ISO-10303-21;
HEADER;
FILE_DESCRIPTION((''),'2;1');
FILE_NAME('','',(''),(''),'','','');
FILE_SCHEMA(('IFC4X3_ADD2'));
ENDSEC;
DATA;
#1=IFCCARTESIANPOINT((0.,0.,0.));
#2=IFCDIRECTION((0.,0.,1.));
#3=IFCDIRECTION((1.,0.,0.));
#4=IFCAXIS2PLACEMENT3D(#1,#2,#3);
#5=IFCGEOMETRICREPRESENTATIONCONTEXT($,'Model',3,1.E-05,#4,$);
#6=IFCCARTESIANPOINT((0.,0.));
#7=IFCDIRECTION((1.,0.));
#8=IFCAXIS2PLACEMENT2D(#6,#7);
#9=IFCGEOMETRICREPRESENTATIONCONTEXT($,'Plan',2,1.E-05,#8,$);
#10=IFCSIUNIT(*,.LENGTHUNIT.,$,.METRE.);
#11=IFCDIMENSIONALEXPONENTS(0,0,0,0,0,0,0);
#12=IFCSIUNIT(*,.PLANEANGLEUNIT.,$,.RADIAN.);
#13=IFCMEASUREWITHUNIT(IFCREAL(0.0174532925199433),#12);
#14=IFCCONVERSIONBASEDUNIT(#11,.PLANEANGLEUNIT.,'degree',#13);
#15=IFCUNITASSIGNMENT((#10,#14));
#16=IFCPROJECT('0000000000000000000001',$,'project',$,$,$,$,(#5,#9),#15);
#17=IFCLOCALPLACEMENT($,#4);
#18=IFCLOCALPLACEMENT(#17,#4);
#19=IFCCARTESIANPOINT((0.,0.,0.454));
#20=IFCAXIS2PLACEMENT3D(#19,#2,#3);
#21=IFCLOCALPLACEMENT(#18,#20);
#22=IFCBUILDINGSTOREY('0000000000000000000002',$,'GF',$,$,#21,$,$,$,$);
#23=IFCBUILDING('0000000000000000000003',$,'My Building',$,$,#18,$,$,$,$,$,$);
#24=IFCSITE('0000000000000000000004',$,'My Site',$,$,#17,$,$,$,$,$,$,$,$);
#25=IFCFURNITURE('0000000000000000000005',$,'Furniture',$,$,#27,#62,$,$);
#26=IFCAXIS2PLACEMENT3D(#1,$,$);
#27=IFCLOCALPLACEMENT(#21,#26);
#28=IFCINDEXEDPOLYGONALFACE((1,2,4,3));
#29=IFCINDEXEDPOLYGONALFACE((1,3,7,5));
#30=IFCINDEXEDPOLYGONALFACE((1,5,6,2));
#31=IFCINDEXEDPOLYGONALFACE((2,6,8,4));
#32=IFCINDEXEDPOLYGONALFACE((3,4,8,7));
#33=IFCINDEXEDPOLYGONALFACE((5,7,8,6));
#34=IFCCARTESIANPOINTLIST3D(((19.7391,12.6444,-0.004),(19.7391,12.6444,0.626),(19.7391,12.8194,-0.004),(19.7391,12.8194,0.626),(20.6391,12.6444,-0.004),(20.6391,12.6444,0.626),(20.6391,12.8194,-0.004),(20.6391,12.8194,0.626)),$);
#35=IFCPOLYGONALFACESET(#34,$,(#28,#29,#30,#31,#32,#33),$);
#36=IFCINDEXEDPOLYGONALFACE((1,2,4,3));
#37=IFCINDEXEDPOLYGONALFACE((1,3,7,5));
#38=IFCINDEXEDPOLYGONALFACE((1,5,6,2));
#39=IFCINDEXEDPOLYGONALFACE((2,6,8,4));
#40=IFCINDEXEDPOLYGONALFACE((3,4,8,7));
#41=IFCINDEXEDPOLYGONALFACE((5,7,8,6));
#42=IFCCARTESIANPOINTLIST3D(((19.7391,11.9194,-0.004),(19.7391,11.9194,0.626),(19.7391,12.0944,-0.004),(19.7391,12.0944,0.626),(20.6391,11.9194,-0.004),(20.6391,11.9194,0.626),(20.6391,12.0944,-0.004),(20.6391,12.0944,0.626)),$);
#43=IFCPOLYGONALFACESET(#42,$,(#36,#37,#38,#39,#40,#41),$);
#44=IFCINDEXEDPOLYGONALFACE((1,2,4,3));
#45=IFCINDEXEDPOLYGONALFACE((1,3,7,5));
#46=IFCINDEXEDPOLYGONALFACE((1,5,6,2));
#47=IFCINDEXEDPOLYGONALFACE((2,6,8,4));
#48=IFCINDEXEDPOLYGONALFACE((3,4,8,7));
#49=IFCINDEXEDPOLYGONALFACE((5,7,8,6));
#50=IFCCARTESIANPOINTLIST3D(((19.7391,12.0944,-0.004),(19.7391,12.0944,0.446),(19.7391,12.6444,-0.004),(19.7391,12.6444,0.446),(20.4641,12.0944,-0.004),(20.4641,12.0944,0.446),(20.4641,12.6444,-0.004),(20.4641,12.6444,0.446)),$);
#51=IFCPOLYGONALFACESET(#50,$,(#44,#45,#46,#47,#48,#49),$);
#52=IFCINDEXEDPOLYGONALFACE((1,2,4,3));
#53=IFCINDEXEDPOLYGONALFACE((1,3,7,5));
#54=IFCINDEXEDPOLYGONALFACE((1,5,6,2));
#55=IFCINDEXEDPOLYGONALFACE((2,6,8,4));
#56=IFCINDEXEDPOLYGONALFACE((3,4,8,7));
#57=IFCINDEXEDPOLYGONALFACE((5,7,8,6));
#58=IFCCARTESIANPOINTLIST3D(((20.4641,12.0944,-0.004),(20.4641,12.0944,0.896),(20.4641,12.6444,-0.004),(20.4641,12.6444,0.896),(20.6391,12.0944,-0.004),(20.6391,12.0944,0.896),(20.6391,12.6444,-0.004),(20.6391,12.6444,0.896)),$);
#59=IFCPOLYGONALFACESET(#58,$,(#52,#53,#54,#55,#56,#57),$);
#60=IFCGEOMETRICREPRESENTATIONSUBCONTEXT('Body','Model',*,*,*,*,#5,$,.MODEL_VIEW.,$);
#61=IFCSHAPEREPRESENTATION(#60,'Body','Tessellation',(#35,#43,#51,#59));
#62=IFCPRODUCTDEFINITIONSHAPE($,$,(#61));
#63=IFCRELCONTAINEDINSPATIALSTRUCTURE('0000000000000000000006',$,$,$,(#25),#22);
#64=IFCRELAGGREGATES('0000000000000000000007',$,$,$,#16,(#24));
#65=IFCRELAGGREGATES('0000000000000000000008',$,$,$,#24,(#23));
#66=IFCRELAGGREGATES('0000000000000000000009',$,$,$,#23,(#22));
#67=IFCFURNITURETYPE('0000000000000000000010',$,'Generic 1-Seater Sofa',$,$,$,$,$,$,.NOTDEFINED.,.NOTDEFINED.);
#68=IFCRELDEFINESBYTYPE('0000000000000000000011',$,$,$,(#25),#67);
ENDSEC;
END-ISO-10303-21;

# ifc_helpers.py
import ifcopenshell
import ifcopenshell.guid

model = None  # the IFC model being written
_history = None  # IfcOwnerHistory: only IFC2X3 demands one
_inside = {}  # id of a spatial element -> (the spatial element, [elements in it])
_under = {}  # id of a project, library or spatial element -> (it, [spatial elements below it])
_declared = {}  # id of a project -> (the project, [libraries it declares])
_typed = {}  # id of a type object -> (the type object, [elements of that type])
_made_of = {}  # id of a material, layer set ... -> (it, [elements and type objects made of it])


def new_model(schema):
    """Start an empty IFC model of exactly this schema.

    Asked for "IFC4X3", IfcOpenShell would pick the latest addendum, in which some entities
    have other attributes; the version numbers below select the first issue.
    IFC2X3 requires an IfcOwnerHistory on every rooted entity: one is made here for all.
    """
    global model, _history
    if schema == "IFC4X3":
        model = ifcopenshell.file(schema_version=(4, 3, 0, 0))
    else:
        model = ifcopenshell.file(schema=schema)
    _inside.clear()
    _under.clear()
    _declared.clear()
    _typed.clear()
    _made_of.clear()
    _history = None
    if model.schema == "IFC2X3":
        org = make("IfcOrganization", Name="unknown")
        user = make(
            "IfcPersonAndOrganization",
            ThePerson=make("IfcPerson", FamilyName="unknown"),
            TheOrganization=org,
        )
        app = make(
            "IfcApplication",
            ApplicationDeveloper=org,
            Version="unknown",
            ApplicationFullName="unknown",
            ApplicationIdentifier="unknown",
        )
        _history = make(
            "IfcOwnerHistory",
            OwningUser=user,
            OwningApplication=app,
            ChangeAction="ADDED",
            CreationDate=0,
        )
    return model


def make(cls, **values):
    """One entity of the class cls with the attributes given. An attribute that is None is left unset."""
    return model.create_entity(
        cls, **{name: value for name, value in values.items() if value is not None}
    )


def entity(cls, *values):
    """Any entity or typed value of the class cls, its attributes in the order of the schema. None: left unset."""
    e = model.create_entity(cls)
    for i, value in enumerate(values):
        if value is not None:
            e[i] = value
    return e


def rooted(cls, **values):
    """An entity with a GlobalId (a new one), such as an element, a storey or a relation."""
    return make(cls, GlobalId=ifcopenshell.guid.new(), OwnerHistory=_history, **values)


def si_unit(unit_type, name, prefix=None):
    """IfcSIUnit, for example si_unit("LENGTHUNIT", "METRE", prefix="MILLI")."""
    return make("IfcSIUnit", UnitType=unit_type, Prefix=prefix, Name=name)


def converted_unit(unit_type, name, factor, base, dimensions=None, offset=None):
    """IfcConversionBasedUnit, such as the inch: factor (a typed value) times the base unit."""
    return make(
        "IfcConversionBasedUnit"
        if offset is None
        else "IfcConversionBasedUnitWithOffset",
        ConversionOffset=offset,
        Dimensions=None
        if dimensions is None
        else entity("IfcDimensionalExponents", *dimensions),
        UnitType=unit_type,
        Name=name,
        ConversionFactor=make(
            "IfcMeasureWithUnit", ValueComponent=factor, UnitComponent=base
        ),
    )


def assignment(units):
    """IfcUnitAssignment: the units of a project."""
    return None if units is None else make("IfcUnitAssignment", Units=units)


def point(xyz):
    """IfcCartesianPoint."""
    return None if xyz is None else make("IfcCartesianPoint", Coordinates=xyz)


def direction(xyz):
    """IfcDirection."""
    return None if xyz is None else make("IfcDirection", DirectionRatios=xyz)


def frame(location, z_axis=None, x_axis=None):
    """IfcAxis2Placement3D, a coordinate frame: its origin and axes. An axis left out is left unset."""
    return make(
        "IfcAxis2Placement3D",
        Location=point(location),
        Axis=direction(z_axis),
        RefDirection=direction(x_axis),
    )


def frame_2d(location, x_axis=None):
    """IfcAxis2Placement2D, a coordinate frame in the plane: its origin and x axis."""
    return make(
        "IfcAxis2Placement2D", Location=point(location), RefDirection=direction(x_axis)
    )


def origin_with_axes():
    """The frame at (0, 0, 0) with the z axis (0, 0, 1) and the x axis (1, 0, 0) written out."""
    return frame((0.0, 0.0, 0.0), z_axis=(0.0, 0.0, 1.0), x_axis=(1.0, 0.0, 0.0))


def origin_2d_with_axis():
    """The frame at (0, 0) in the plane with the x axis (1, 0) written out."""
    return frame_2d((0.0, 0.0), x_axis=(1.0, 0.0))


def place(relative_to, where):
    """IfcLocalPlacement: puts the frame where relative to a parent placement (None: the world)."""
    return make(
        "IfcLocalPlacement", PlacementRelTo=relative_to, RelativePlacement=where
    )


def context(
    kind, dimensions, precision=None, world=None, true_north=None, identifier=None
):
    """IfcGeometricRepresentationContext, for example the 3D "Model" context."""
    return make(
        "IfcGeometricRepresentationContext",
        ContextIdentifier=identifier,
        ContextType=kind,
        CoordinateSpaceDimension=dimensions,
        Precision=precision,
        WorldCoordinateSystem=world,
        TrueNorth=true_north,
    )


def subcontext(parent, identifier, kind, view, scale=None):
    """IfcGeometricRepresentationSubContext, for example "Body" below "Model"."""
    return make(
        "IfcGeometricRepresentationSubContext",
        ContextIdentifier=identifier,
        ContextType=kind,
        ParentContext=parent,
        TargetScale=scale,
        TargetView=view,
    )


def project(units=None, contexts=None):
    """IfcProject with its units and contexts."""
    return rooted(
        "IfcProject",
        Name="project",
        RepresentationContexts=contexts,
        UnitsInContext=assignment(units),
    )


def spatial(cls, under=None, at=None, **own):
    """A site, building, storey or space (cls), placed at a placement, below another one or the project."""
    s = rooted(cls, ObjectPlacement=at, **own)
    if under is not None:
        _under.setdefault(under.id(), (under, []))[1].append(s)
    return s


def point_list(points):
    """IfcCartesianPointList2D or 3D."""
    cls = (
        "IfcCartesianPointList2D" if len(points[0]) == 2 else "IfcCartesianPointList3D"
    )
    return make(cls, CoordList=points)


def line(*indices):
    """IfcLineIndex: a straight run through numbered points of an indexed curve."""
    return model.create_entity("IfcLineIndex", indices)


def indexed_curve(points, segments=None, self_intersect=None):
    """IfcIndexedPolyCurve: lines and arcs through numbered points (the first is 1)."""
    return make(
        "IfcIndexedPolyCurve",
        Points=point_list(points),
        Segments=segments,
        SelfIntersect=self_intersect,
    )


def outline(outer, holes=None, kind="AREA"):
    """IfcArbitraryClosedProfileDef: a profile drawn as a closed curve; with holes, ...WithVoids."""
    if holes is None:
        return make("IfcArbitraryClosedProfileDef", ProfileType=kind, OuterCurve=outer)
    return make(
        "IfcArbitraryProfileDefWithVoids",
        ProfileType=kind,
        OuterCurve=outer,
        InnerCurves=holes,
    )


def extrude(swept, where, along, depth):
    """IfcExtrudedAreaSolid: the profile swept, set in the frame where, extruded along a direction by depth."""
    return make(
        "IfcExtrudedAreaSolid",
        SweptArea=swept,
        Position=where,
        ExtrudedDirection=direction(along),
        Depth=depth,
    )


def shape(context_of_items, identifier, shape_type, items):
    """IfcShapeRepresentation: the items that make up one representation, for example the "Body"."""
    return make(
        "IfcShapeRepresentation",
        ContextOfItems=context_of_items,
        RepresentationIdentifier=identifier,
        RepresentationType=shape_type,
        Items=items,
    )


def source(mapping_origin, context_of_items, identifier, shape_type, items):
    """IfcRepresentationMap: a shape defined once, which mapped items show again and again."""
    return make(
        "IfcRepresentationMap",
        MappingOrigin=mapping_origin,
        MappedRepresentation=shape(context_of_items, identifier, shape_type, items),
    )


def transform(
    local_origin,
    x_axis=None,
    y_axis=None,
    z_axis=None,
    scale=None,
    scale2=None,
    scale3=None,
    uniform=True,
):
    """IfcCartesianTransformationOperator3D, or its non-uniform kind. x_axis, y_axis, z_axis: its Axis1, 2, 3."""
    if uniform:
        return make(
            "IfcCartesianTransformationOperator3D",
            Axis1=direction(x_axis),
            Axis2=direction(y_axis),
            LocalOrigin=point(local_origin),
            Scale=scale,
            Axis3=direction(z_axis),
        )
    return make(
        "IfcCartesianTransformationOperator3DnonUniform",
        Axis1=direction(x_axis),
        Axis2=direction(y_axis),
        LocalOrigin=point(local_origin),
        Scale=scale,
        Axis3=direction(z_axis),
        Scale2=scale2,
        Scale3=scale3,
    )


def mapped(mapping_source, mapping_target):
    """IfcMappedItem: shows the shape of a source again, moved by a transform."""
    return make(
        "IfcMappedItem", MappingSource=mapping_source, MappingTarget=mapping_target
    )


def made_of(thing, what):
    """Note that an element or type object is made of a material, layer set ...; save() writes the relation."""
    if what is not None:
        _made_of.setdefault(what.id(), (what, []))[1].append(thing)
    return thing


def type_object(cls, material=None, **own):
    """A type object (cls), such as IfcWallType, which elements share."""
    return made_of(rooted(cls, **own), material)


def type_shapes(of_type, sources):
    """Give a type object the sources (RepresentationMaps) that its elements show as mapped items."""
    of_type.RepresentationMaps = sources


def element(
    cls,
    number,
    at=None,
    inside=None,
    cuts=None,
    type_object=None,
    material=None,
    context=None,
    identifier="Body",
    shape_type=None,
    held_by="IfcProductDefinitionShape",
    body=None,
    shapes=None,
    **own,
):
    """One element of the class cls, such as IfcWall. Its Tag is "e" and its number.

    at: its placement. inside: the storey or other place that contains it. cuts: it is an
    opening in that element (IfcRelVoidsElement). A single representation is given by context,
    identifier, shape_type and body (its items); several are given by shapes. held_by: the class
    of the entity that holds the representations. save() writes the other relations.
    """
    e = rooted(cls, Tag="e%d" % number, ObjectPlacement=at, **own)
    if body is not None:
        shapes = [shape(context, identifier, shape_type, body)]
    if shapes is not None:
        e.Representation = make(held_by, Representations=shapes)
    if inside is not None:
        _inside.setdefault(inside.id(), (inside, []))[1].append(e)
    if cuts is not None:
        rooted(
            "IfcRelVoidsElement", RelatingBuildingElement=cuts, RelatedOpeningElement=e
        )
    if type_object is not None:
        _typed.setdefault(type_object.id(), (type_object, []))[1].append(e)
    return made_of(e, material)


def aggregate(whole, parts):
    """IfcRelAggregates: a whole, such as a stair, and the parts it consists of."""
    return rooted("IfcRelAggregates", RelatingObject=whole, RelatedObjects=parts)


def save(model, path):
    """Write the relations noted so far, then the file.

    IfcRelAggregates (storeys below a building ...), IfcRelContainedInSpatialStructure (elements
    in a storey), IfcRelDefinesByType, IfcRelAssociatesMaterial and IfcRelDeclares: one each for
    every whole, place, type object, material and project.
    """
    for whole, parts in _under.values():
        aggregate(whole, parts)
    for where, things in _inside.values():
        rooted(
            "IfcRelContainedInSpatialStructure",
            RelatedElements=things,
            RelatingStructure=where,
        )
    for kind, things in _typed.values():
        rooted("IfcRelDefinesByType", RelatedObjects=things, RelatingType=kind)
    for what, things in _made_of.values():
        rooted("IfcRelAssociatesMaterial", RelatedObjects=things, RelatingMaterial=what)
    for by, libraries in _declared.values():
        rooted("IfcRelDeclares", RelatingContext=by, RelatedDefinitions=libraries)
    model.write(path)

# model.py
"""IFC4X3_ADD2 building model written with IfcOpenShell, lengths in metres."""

from ifc_helpers import new_model, entity, si_unit, converted_unit, frame, origin_with_axes, origin_2d_with_axis, place, context, subcontext, project, spatial, line, indexed_curve, outline, extrude, shape, source, transform, mapped, type_object, type_shapes, element, save


model = new_model("IFC4X3_ADD2")

# Units and contexts
model_context = context("Model", 3, precision=1e-05, world=origin_with_axes())
plan_context = context("Plan", 2, precision=1e-05, world=origin_2d_with_axis())
body_context_1 = subcontext(model_context, "Body", "Model", "MODEL_VIEW")
body_context_2 = subcontext(plan_context, "Body", "Plan", "PLAN_VIEW")
ifc_project = project(units=[si_unit("LENGTHUNIT", "METRE"), converted_unit("PLANEANGLEUNIT", "degree", entity("IfcReal", 0.0174532925199433), si_unit("PLANEANGLEUNIT", "RADIAN"), dimensions=[0, 0, 0, 0, 0, 0, 0])], contexts=[model_context, plan_context])

# Site, building, storey
site_placement = place(None, origin_with_axes())
site = spatial("IfcSite", under=ifc_project, at=site_placement, Name="My Site")
building_placement = place(site_placement, origin_with_axes())
building = spatial("IfcBuilding", under=site, at=building_placement, Name="My Building")
storey_placement = place(building_placement, frame((0.0, 0.0, 0.454), z_axis=(0.0, 0.0, 1.0), x_axis=(1.0, 0.0, 0.0)))
storey = spatial("IfcBuildingStorey", under=building, at=storey_placement, Name="GF")

# Furniture
furniture_type = type_object("IfcFurnitureType", Name="Generic 1-Seater Sofa", AssemblyPlace="NOTDEFINED", PredefinedType="NOTDEFINED")
shared_shape_1 = source(origin_with_axes(), body_context_1, "Body", "SweptSolid", [
    extrude(outline(indexed_curve([(0.0, 0.0), (0.175, 0.0), (0.175, 0.9), (0.0, 0.9)], segments=[line(1, 2, 3, 4, 1)])), frame((-0.45, -0.9, 0.0), z_axis=(0.0, 0.0, 1.0), x_axis=(1.0, 0.0, 0.0)), (0.0, 0.0, 1.0), 0.63),
    extrude(outline(indexed_curve([(0.0, 0.0), (0.175, 0.0), (0.175, 0.9), (0.0, 0.9)], segments=[line(1, 2, 3, 4, 1)])), frame((0.275, -0.9, 0.0), z_axis=(0.0, 0.0, 1.0), x_axis=(1.0, 0.0, 0.0)), (0.0, 0.0, 1.0), 0.63),
    extrude(outline(indexed_curve([(0.175, 0.0), (0.725, 0.0), (0.725, 0.725), (0.175, 0.725)], segments=[line(1, 2, 3, 4, 1)])), frame((-0.45, -0.9, 0.0), z_axis=(0.0, 0.0, 1.0), x_axis=(1.0, 0.0, 0.0)), (0.0, 0.0, 1.0), 0.45),
    extrude(outline(indexed_curve([(0.175, 0.725), (0.725, 0.725), (0.725, 0.9), (0.175, 0.9)], segments=[line(1, 2, 3, 4, 1)])), frame((-0.45, -0.9, 0.0), z_axis=(0.0, 0.0, 1.0), x_axis=(1.0, 0.0, 0.0)), (0.0, 0.0, 1.0), 0.9),
])
shared_shape_2 = source(origin_with_axes(), body_context_2, "Body", "Annotation2D", [
    entity("IfcGeometricCurveSet", [entity("IfcIndexedPolyCurve", entity("IfcCartesianPointList2D", [[0.275, -0.175], [0.275, -0.9], [0.45, -0.9], [0.45, 0.0], [0.275, 0.0], [0.275, -0.9], [-0.275, -0.9], [-0.275, 0.0], [-0.275, -0.175], [0.275, -0.175], [0.275, 0.0], [-0.275, 0.0], [-0.45, 0.0], [-0.45, -0.9], [-0.275, -0.9], [-0.275, -0.175]]))]),
])
type_shapes(furniture_type, [shared_shape_1, shared_shape_2])
furniture_placement = place(storey_placement, frame((20.6391, 12.3694, -0.004), z_axis=(0.0, 0.0, 1.0), x_axis=(0.0, -1.0, 0.0)))
element("IfcFurniture", 1, at=furniture_placement, inside=storey, type_object=furniture_type, Name="Furniture", shapes=[
    shape(body_context_1, "Body", "MappedRepresentation", [mapped(shared_shape_1, transform((0.0, 0.0, 0.0), x_axis=(1.0, 0.0, 0.0), y_axis=(0.0, 1.0, 0.0), z_axis=(0.0, 0.0, 1.0), scale=1.0))]),
    shape(body_context_2, "Body", "MappedRepresentation", [mapped(shared_shape_2, transform((0.0, 0.0, 0.0), x_axis=(1.0, 0.0, 0.0), y_axis=(0.0, 1.0, 0.0), z_axis=(0.0, 0.0, 1.0), scale=1.0))]),
])

save(model, "model.ifc")
